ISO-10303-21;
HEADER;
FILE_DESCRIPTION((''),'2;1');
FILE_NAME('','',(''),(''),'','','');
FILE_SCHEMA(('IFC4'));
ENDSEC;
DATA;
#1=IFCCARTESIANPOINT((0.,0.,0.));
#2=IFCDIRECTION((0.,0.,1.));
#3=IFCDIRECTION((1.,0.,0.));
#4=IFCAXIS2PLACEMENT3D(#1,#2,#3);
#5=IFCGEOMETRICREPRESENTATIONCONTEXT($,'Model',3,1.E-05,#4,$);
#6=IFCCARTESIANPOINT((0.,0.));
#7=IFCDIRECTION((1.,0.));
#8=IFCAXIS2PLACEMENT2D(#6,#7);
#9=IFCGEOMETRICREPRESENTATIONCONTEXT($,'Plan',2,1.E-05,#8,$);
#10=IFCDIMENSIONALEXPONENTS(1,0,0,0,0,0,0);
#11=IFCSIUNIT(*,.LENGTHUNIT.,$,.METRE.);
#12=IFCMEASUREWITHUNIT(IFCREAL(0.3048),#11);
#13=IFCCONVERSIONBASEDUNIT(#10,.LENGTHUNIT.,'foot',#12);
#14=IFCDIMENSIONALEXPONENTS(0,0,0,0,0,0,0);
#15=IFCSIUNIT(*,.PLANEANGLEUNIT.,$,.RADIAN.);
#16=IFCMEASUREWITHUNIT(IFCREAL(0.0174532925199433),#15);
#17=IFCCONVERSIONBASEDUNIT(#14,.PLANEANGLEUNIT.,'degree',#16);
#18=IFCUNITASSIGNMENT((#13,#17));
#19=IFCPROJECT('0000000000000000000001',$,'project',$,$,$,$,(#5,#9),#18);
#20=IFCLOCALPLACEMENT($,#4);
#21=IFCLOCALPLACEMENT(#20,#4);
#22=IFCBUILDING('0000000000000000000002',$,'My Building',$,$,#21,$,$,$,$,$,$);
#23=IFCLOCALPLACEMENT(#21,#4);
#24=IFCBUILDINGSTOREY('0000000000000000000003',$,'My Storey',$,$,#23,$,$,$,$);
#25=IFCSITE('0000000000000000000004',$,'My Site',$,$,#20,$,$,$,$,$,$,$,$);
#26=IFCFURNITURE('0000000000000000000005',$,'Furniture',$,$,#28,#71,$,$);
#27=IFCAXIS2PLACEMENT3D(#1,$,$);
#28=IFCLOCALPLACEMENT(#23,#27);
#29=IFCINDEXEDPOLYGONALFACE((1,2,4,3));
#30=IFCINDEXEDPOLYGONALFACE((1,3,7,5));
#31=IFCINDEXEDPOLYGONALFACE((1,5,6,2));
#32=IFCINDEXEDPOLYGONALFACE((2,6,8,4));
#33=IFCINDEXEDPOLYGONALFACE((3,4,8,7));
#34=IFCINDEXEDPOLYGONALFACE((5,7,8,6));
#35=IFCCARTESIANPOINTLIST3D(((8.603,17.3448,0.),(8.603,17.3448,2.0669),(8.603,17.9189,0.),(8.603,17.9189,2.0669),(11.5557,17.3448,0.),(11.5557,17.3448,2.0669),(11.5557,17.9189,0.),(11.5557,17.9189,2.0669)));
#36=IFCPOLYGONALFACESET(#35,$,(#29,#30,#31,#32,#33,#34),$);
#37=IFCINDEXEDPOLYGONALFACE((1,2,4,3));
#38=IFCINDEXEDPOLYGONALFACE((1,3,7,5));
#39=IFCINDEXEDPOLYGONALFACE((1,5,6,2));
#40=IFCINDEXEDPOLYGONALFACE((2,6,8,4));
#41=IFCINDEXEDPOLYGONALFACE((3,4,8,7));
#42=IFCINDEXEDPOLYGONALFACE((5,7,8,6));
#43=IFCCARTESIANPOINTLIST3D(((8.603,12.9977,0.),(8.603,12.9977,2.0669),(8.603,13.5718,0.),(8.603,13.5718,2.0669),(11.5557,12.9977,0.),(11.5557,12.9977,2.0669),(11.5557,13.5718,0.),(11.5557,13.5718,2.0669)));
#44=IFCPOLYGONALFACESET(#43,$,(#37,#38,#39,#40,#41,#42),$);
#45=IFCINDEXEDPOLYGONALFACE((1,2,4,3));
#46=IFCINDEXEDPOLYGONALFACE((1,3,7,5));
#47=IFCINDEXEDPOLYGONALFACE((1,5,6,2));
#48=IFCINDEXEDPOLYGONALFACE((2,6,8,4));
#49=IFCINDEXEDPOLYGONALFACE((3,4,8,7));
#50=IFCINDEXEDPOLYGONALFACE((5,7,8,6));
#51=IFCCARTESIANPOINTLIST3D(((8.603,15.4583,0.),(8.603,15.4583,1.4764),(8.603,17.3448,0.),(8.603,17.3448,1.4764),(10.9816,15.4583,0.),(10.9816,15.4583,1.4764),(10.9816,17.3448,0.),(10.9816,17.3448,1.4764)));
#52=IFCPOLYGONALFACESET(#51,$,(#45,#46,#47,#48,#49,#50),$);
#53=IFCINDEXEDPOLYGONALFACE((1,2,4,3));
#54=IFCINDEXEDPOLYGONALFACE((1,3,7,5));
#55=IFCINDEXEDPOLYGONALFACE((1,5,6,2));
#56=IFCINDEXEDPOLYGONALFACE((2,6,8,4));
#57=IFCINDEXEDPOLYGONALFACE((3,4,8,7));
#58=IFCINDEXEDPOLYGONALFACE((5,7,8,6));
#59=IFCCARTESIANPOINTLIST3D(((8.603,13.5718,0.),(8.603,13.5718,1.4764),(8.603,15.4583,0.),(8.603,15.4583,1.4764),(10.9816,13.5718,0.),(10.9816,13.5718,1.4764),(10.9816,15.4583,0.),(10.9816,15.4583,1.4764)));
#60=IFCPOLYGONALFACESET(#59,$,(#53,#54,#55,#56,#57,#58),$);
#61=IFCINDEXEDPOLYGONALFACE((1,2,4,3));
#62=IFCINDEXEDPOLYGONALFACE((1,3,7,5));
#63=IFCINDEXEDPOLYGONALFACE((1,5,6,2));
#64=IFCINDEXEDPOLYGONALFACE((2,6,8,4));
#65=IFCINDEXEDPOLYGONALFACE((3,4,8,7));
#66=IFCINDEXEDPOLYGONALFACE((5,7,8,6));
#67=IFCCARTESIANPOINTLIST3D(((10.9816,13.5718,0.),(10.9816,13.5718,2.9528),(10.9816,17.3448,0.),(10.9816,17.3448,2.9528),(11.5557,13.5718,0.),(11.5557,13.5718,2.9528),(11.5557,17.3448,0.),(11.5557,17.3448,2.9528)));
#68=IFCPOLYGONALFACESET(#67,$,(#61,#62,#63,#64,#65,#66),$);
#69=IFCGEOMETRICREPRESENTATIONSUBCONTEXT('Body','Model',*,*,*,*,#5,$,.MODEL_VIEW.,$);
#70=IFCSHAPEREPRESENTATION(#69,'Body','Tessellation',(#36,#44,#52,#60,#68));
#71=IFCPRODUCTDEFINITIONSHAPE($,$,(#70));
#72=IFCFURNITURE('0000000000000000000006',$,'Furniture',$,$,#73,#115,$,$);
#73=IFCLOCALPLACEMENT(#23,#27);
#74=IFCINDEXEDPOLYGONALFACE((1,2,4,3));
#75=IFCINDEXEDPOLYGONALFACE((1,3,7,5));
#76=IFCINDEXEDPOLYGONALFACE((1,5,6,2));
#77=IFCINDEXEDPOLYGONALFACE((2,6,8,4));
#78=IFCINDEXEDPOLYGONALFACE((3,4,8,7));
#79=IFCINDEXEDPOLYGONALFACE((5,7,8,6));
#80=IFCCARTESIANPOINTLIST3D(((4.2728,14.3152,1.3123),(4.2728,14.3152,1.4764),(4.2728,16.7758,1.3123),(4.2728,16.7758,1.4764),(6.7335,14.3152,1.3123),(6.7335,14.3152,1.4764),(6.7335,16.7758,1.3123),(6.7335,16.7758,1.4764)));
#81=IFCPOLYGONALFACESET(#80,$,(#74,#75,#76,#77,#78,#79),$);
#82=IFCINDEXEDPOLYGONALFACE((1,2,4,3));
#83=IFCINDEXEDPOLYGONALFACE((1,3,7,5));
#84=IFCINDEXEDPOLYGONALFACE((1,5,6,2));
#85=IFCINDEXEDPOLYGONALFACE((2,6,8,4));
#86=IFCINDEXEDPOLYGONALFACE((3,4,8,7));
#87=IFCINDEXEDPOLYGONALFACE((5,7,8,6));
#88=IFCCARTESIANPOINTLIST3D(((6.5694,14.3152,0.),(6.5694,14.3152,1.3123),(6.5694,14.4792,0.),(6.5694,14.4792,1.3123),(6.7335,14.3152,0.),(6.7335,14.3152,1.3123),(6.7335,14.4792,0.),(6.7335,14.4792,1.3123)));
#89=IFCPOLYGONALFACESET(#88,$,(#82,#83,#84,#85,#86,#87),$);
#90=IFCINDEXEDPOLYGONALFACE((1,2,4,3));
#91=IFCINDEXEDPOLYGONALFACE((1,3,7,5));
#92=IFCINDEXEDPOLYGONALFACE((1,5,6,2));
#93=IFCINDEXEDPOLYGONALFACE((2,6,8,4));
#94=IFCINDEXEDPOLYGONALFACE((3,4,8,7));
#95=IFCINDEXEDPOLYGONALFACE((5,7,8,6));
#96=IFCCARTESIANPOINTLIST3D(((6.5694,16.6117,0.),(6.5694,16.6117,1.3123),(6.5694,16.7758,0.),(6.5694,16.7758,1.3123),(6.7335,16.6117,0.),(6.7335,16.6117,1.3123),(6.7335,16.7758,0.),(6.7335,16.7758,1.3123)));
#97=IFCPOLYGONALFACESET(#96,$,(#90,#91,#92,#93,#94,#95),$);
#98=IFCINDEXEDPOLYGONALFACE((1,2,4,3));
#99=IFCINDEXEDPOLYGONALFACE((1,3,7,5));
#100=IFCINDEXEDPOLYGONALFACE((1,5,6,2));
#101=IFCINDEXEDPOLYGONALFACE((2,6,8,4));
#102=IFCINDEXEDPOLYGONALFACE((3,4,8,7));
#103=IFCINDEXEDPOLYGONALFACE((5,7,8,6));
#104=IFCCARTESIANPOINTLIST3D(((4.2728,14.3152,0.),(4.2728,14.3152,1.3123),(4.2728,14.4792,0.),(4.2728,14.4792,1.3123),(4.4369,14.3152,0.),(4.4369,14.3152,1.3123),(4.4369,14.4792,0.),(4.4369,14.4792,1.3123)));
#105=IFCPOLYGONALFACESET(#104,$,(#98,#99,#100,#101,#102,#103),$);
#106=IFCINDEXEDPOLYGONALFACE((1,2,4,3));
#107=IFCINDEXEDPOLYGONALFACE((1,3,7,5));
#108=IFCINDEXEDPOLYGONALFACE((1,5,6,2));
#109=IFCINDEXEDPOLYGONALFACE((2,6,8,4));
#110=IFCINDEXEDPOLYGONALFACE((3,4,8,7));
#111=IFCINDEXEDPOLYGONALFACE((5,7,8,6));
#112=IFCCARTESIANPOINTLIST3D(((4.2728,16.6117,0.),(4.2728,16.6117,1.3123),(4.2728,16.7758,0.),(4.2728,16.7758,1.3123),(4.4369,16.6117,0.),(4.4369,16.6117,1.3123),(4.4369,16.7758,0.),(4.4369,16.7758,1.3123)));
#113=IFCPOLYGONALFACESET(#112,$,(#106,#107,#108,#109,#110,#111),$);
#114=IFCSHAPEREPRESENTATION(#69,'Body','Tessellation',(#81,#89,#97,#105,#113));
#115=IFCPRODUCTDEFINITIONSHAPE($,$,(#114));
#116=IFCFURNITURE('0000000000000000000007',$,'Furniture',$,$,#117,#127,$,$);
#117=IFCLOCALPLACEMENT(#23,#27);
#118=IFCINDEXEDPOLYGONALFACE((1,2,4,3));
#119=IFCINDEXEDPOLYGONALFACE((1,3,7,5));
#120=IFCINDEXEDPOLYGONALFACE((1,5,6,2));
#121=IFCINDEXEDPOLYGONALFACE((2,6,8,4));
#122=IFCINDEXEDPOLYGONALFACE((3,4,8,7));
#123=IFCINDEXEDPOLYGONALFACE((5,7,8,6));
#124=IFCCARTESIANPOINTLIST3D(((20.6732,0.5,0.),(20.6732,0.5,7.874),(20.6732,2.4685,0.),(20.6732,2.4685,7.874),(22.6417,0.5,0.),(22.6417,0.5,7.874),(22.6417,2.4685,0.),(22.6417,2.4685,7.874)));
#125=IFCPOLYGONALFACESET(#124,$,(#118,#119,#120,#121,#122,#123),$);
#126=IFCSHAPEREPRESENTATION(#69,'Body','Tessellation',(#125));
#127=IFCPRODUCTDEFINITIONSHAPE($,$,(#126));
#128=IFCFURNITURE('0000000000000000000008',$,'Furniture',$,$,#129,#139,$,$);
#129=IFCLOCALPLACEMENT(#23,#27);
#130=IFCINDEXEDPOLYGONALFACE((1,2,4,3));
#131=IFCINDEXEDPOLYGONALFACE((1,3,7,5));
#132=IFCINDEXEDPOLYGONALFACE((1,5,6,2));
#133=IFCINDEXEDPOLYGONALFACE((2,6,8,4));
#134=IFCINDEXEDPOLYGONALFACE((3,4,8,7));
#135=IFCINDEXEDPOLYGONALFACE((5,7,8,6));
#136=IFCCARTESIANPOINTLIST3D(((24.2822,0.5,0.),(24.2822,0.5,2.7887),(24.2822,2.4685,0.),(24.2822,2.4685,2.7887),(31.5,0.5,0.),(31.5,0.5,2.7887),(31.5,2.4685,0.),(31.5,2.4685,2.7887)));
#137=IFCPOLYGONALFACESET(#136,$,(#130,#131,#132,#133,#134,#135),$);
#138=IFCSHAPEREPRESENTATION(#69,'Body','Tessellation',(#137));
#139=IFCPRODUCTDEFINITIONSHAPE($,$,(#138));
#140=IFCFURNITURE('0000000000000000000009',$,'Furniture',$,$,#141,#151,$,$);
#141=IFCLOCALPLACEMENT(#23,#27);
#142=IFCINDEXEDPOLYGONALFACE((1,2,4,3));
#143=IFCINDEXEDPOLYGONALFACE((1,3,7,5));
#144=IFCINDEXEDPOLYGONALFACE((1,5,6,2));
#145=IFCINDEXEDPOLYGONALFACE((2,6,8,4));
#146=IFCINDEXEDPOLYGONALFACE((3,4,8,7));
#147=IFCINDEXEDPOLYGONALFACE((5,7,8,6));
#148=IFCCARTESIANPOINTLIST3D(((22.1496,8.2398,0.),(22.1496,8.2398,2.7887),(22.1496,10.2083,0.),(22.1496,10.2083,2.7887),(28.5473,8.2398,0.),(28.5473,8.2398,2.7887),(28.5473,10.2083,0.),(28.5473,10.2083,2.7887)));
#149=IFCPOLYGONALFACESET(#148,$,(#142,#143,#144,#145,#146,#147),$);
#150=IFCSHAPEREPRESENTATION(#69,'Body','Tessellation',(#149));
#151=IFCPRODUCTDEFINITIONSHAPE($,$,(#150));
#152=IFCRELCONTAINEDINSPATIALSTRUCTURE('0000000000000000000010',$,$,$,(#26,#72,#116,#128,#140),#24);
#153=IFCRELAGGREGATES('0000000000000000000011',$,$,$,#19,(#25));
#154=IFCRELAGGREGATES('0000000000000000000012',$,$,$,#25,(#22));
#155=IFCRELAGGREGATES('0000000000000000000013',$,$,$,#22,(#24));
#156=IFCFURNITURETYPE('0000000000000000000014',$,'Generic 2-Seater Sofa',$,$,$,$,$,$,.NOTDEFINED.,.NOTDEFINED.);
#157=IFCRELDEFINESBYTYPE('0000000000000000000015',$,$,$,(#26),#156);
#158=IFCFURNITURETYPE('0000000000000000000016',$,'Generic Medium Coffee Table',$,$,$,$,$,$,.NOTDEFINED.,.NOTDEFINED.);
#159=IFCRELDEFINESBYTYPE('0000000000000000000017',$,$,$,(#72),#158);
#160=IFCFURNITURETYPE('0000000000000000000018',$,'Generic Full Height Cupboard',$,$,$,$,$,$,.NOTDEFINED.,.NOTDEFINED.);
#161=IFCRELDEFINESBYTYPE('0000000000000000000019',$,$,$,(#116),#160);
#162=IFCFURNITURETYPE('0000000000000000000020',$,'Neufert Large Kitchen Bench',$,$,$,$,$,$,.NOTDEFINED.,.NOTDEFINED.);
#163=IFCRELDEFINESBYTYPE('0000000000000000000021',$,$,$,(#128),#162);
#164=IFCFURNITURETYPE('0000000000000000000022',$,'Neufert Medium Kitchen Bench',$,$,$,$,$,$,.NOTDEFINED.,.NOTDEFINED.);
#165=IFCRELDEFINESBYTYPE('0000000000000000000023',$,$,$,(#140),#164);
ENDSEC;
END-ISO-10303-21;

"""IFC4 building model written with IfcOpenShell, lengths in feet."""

from ifc_helpers import new_model, entity, si_unit, converted_unit, frame, origin_with_axes, origin_2d_with_axis, place, context, subcontext, project, spatial, line, indexed_curve, outline, extrude, shape, source, transform, mapped, type_object, type_shapes, element, save


model = new_model("IFC4")

# Units and contexts
model_context = context("Model", 3, precision=1e-05, world=origin_with_axes())
plan_context = context("Plan", 2, precision=1e-05, world=origin_2d_with_axis())
body_context_1 = subcontext(model_context, "Body", "Model", "MODEL_VIEW")
body_context_2 = subcontext(plan_context, "Body", "Plan", "PLAN_VIEW")
ifc_project = project(units=[converted_unit("LENGTHUNIT", "foot", entity("IfcReal", 0.3048), si_unit("LENGTHUNIT", "METRE"), dimensions=[1, 0, 0, 0, 0, 0, 0]), converted_unit("PLANEANGLEUNIT", "degree", entity("IfcReal", 0.0174532925199433), si_unit("PLANEANGLEUNIT", "RADIAN"), dimensions=[0, 0, 0, 0, 0, 0, 0])], contexts=[model_context, plan_context])

# Site, building, storey
site_placement = place(None, origin_with_axes())
site = spatial("IfcSite", under=ifc_project, at=site_placement, Name="My Site")
building_placement = place(site_placement, origin_with_axes())
building = spatial("IfcBuilding", under=site, at=building_placement, Name="My Building")
storey_placement = place(building_placement, origin_with_axes())
storey = spatial("IfcBuildingStorey", under=building, at=storey_placement, Name="My Storey")

# Furniture
furniture_type_1 = type_object("IfcFurnitureType", Name="Generic 2-Seater Sofa", AssemblyPlace="NOTDEFINED", PredefinedType="NOTDEFINED")
shared_shape_1 = source(origin_with_axes(), body_context_1, "Body", "SweptSolid", [
    extrude(outline(indexed_curve([(0.0, 0.0), (0.5741, 0.0), (0.5741, 2.9528), (0.0, 2.9528)], segments=[line(1, 2, 3, 4, 1)])), frame((-2.4606, -2.9528, 0.0), z_axis=(0.0, 0.0, 1.0), x_axis=(1.0, 0.0, 0.0)), (0.0, 0.0, 1.0), 2.0669),
    extrude(outline(indexed_curve([(0.0, 0.0), (0.5741, 0.0), (0.5741, 2.9528), (0.0, 2.9528)], segments=[line(1, 2, 3, 4, 1)])), frame((1.8865, -2.9528, 0.0), z_axis=(0.0, 0.0, 1.0), x_axis=(1.0, 0.0, 0.0)), (0.0, 0.0, 1.0), 2.0669),
    extrude(outline(indexed_curve([(0.5741, 0.0), (2.4606, 0.0), (2.4606, 2.3786), (0.5741, 2.3786)], segments=[line(1, 2, 3, 4, 1)])), frame((-2.4606, -2.9528, 0.0), z_axis=(0.0, 0.0, 1.0), x_axis=(1.0, 0.0, 0.0)), (0.0, 0.0, 1.0), 1.4764),
    extrude(outline(indexed_curve([(2.4606, 0.0), (4.3471, 0.0), (4.3471, 2.3786), (2.4606, 2.3786)], segments=[line(1, 2, 3, 4, 1)])), frame((-2.4606, -2.9528, 0.0), z_axis=(0.0, 0.0, 1.0), x_axis=(1.0, 0.0, 0.0)), (0.0, 0.0, 1.0), 1.4764),
    extrude(outline(indexed_curve([(0.5741, 2.3786), (4.3471, 2.3786), (4.3471, 2.9528), (0.5741, 2.9528)], segments=[line(1, 2, 3, 4, 1)])), frame((-2.4606, -2.9528, 0.0), z_axis=(0.0, 0.0, 1.0), x_axis=(1.0, 0.0, 0.0)), (0.0, 0.0, 1.0), 2.9528),
])
shared_shape_2 = source(origin_with_axes(), body_context_2, "Body", "Curve2D", [
    entity("IfcIndexedPolyCurve", entity("IfcCartesianPointList2D", [[-2.4606, -2.9528], [-1.8865, -2.9528], [-1.8865, 0.0], [-2.4606, 0.0]]), [entity("IfcLineIndex", [1, 2, 3, 4, 1])]),
    entity("IfcIndexedPolyCurve", entity("IfcCartesianPointList2D", [[1.8865, -2.9528], [2.4606, -2.9528], [2.4606, 0.0], [1.8865, 0.0]]), [entity("IfcLineIndex", [1, 2, 3, 4, 1])]),
    entity("IfcIndexedPolyCurve", entity("IfcCartesianPointList2D", [[-1.8865, -2.9528], [0.0, -2.9528], [0.0, -0.5741], [-1.8865, -0.5741]]), [entity("IfcLineIndex", [1, 2, 3, 4, 1])]),
    entity("IfcIndexedPolyCurve", entity("IfcCartesianPointList2D", [[0.0, -2.9528], [1.8865, -2.9528], [1.8865, -0.5741], [0.0, -0.5741]]), [entity("IfcLineIndex", [1, 2, 3, 4, 1])]),
    entity("IfcIndexedPolyCurve", entity("IfcCartesianPointList2D", [[-1.8865, -0.5741], [1.8865, -0.5741], [1.8865, 0.0], [-1.8865, 0.0]]), [entity("IfcLineIndex", [1, 2, 3, 4, 1])]),
])
type_shapes(furniture_type_1, [shared_shape_1, shared_shape_2])
furniture_1_placement = place(storey_placement, frame((11.5557, 15.4583, 0.0), z_axis=(0.0, 0.0, 1.0), x_axis=(0.0, -1.0, 0.0)))
element("IfcFurniture", 1, at=furniture_1_placement, inside=storey, type_object=furniture_type_1, Name="Furniture", shapes=[
    shape(body_context_1, "Body", "MappedRepresentation", [mapped(shared_shape_1, transform((0.0, 0.0, 0.0), x_axis=(1.0, 0.0, 0.0), y_axis=(0.0, 1.0, 0.0), z_axis=(0.0, 0.0, 1.0), scale=1.0))]),
    shape(body_context_2, "Body", "MappedRepresentation", [mapped(shared_shape_2, transform((0.0, 0.0, 0.0), x_axis=(1.0, 0.0, 0.0), y_axis=(0.0, 1.0, 0.0), z_axis=(0.0, 0.0, 1.0), scale=1.0))]),
])
furniture_type_2 = type_object("IfcFurnitureType", Name="Generic Medium Coffee Table", AssemblyPlace="NOTDEFINED", PredefinedType="NOTDEFINED")
shared_shape_3 = source(origin_with_axes(), body_context_1, "Body", "SweptSolid", [
    extrude(outline(indexed_curve([(0.0, 0.0), (2.4606, 0.0), (2.4606, 2.4606), (0.0, 2.4606)], segments=[line(1, 2, 3, 4, 1)])), frame((-1.2303, -1.2303, 1.3123), z_axis=(0.0, 0.0, 1.0), x_axis=(1.0, 0.0, 0.0)), (0.0, 0.0, 1.0), 0.164),
    extrude(outline(indexed_curve([(0.0, 0.0), (0.164, 0.0), (0.164, 0.164), (0.0, 0.164)], segments=[line(1, 2, 3, 4, 1)])), frame((-1.2303, -1.2303, 0.0), z_axis=(0.0, 0.0, 1.0), x_axis=(1.0, 0.0, 0.0)), (0.0, 0.0, 1.0), 1.3123),
    extrude(outline(indexed_curve([(2.4606, 0.0), (2.2966, 0.0), (2.2966, 0.164), (2.4606, 0.164)], segments=[line(1, 2, 3, 4, 1)])), frame((-1.2303, -1.2303, 0.0), z_axis=(0.0, 0.0, 1.0), x_axis=(1.0, 0.0, 0.0)), (0.0, 0.0, 1.0), 1.3123),
    extrude(outline(indexed_curve([(0.0, 2.4606), (0.164, 2.4606), (0.164, 2.2966), (0.0, 2.2966)], segments=[line(1, 2, 3, 4, 1)])), frame((-1.2303, -1.2303, 0.0), z_axis=(0.0, 0.0, 1.0), x_axis=(1.0, 0.0, 0.0)), (0.0, 0.0, 1.0), 1.3123),
    extrude(outline(indexed_curve([(2.4606, 2.4606), (2.2966, 2.4606), (2.2966, 2.2966), (2.4606, 2.2966)], segments=[line(1, 2, 3, 4, 1)])), frame((-1.2303, -1.2303, 0.0), z_axis=(0.0, 0.0, 1.0), x_axis=(1.0, 0.0, 0.0)), (0.0, 0.0, 1.0), 1.3123),
])
shared_shape_4 = source(origin_with_axes(), body_context_2, "Body", "Curve2D", [
    entity("IfcIndexedPolyCurve", entity("IfcCartesianPointList2D", [[-1.2303, -1.2303], [1.2303, -1.2303], [1.2303, 1.2303], [-1.2303, 1.2303]]), [entity("IfcLineIndex", [1, 2, 3, 4, 1])]),
])
type_shapes(furniture_type_2, [shared_shape_3, shared_shape_4])
furniture_2_placement = place(storey_placement, frame((5.5032, 15.5455, 0.0), z_axis=(0.0, 0.0, 1.0), x_axis=(0.0, 1.0, 0.0)))
element("IfcFurniture", 2, at=furniture_2_placement, inside=storey, type_object=furniture_type_2, Name="Furniture", shapes=[
    shape(body_context_1, "Body", "MappedRepresentation", [mapped(shared_shape_3, transform((0.0, 0.0, 0.0), x_axis=(1.0, 0.0, 0.0), y_axis=(0.0, 1.0, 0.0), z_axis=(0.0, 0.0, 1.0), scale=1.0))]),
    shape(body_context_2, "Body", "MappedRepresentation", [mapped(shared_shape_4, transform((0.0, 0.0, 0.0), x_axis=(1.0, 0.0, 0.0), y_axis=(0.0, 1.0, 0.0), z_axis=(0.0, 0.0, 1.0), scale=1.0))]),
])
furniture_type_3 = type_object("IfcFurnitureType", Name="Generic Full Height Cupboard", AssemblyPlace="NOTDEFINED", PredefinedType="NOTDEFINED")
shared_shape_5 = source(origin_with_axes(), body_context_1, "Body", "SweptSolid", [
    extrude(outline(indexed_curve([(0.0, 0.0), (1.9685, 0.0), (1.9685, 1.9685), (0.0, 1.9685)], segments=[line(1, 2, 3, 4, 1)])), origin_with_axes(), (0.0, 0.0, 1.0), 7.874),
])
shared_shape_6 = source(origin_with_axes(), body_context_2, "Body", "Curve2D", [
    entity("IfcIndexedPolyCurve", entity("IfcCartesianPointList2D", [[0.0, 0.0], [1.9685, 0.0], [1.9685, 1.9685], [0.0, 1.9685]]), [entity("IfcLineIndex", [1, 2, 3, 4, 1])]),
])
type_shapes(furniture_type_3, [shared_shape_5, shared_shape_6])
furniture_3_placement = place(storey_placement, frame((20.6732, 0.5, 0.0), z_axis=(0.0, 0.0, 1.0), x_axis=(1.0, 0.0, 0.0)))
element("IfcFurniture", 3, at=furniture_3_placement, inside=storey, type_object=furniture_type_3, Name="Furniture", shapes=[
    shape(body_context_1, "Body", "MappedRepresentation", [mapped(shared_shape_5, transform((0.0, 0.0, 0.0), x_axis=(1.0, 0.0, 0.0), y_axis=(0.0, 1.0, 0.0), z_axis=(0.0, 0.0, 1.0), scale=1.0))]),
    shape(body_context_2, "Body", "MappedRepresentation", [mapped(shared_shape_6, transform((0.0, 0.0, 0.0), x_axis=(1.0, 0.0, 0.0), y_axis=(0.0, 1.0, 0.0), z_axis=(0.0, 0.0, 1.0), scale=1.0))]),
])
furniture_type_4 = type_object("IfcFurnitureType", Name="Neufert Large Kitchen Bench", AssemblyPlace="NOTDEFINED", PredefinedType="NOTDEFINED")
shared_shape_7 = source(origin_with_axes(), body_context_1, "Body", "SweptSolid", [
    extrude(outline(indexed_curve([(0.0, 0.0), (7.2178, 0.0), (7.2178, 1.9685), (0.0, 1.9685)], segments=[line(1, 2, 3, 4, 1)])), origin_with_axes(), (0.0, 0.0, 1.0), 2.7887),
])
shared_shape_8 = source(origin_with_axes(), body_context_2, "Body", "Curve2D", [
    entity("IfcIndexedPolyCurve", entity("IfcCartesianPointList2D", [[0.0, 0.0], [7.2178, 0.0], [7.2178, 1.9685], [0.0, 1.9685]]), [entity("IfcLineIndex", [1, 2, 3, 4, 1])]),
])
type_shapes(furniture_type_4, [shared_shape_7, shared_shape_8])
furniture_4_placement = place(storey_placement, frame((24.2822, 0.5, 0.0), z_axis=(0.0, 0.0, 1.0), x_axis=(1.0, 0.0, 0.0)))
element("IfcFurniture", 4, at=furniture_4_placement, inside=storey, type_object=furniture_type_4, Name="Furniture", shapes=[
    shape(body_context_1, "Body", "MappedRepresentation", [mapped(shared_shape_7, transform((0.0, 0.0, 0.0), x_axis=(1.0, 0.0, 0.0), y_axis=(0.0, 1.0, 0.0), z_axis=(0.0, 0.0, 1.0), scale=1.0))]),
    shape(body_context_2, "Body", "MappedRepresentation", [mapped(shared_shape_8, transform((0.0, 0.0, 0.0), x_axis=(1.0, 0.0, 0.0), y_axis=(0.0, 1.0, 0.0), z_axis=(0.0, 0.0, 1.0), scale=1.0))]),
])
furniture_type_5 = type_object("IfcFurnitureType", Name="Neufert Medium Kitchen Bench", AssemblyPlace="NOTDEFINED", PredefinedType="NOTDEFINED")
shared_shape_9 = source(origin_with_axes(), body_context_1, "Body", "SweptSolid", [
    extrude(outline(indexed_curve([(0.0, 0.0), (6.3976, 0.0), (6.3976, 1.9685), (0.0, 1.9685)], segments=[line(1, 2, 3, 4, 1)])), origin_with_axes(), (0.0, 0.0, 1.0), 2.7887),
])
shared_shape_10 = source(origin_with_axes(), body_context_2, "Body", "Curve2D", [
    entity("IfcIndexedPolyCurve", entity("IfcCartesianPointList2D", [[0.0, 0.0], [6.3976, 0.0], [6.3976, 1.9685], [0.0, 1.9685]]), [entity("IfcLineIndex", [1, 2, 3, 4, 1])]),
])
type_shapes(furniture_type_5, [shared_shape_9, shared_shape_10])
furniture_5_placement = place(storey_placement, frame((22.1496, 8.2398, 0.0), z_axis=(0.0, 0.0, 1.0), x_axis=(1.0, 0.0, 0.0)))
element("IfcFurniture", 5, at=furniture_5_placement, inside=storey, type_object=furniture_type_5, Name="Furniture", shapes=[
    shape(body_context_1, "Body", "MappedRepresentation", [mapped(shared_shape_9, transform((0.0, 0.0, 0.0), x_axis=(1.0, 0.0, 0.0), y_axis=(0.0, 1.0, 0.0), z_axis=(0.0, 0.0, 1.0), scale=1.0))]),
    shape(body_context_2, "Body", "MappedRepresentation", [mapped(shared_shape_10, transform((0.0, 0.0, 0.0), x_axis=(1.0, 0.0, 0.0), y_axis=(0.0, 1.0, 0.0), z_axis=(0.0, 0.0, 1.0), scale=1.0))]),
])

save(model, "model.ifc")
